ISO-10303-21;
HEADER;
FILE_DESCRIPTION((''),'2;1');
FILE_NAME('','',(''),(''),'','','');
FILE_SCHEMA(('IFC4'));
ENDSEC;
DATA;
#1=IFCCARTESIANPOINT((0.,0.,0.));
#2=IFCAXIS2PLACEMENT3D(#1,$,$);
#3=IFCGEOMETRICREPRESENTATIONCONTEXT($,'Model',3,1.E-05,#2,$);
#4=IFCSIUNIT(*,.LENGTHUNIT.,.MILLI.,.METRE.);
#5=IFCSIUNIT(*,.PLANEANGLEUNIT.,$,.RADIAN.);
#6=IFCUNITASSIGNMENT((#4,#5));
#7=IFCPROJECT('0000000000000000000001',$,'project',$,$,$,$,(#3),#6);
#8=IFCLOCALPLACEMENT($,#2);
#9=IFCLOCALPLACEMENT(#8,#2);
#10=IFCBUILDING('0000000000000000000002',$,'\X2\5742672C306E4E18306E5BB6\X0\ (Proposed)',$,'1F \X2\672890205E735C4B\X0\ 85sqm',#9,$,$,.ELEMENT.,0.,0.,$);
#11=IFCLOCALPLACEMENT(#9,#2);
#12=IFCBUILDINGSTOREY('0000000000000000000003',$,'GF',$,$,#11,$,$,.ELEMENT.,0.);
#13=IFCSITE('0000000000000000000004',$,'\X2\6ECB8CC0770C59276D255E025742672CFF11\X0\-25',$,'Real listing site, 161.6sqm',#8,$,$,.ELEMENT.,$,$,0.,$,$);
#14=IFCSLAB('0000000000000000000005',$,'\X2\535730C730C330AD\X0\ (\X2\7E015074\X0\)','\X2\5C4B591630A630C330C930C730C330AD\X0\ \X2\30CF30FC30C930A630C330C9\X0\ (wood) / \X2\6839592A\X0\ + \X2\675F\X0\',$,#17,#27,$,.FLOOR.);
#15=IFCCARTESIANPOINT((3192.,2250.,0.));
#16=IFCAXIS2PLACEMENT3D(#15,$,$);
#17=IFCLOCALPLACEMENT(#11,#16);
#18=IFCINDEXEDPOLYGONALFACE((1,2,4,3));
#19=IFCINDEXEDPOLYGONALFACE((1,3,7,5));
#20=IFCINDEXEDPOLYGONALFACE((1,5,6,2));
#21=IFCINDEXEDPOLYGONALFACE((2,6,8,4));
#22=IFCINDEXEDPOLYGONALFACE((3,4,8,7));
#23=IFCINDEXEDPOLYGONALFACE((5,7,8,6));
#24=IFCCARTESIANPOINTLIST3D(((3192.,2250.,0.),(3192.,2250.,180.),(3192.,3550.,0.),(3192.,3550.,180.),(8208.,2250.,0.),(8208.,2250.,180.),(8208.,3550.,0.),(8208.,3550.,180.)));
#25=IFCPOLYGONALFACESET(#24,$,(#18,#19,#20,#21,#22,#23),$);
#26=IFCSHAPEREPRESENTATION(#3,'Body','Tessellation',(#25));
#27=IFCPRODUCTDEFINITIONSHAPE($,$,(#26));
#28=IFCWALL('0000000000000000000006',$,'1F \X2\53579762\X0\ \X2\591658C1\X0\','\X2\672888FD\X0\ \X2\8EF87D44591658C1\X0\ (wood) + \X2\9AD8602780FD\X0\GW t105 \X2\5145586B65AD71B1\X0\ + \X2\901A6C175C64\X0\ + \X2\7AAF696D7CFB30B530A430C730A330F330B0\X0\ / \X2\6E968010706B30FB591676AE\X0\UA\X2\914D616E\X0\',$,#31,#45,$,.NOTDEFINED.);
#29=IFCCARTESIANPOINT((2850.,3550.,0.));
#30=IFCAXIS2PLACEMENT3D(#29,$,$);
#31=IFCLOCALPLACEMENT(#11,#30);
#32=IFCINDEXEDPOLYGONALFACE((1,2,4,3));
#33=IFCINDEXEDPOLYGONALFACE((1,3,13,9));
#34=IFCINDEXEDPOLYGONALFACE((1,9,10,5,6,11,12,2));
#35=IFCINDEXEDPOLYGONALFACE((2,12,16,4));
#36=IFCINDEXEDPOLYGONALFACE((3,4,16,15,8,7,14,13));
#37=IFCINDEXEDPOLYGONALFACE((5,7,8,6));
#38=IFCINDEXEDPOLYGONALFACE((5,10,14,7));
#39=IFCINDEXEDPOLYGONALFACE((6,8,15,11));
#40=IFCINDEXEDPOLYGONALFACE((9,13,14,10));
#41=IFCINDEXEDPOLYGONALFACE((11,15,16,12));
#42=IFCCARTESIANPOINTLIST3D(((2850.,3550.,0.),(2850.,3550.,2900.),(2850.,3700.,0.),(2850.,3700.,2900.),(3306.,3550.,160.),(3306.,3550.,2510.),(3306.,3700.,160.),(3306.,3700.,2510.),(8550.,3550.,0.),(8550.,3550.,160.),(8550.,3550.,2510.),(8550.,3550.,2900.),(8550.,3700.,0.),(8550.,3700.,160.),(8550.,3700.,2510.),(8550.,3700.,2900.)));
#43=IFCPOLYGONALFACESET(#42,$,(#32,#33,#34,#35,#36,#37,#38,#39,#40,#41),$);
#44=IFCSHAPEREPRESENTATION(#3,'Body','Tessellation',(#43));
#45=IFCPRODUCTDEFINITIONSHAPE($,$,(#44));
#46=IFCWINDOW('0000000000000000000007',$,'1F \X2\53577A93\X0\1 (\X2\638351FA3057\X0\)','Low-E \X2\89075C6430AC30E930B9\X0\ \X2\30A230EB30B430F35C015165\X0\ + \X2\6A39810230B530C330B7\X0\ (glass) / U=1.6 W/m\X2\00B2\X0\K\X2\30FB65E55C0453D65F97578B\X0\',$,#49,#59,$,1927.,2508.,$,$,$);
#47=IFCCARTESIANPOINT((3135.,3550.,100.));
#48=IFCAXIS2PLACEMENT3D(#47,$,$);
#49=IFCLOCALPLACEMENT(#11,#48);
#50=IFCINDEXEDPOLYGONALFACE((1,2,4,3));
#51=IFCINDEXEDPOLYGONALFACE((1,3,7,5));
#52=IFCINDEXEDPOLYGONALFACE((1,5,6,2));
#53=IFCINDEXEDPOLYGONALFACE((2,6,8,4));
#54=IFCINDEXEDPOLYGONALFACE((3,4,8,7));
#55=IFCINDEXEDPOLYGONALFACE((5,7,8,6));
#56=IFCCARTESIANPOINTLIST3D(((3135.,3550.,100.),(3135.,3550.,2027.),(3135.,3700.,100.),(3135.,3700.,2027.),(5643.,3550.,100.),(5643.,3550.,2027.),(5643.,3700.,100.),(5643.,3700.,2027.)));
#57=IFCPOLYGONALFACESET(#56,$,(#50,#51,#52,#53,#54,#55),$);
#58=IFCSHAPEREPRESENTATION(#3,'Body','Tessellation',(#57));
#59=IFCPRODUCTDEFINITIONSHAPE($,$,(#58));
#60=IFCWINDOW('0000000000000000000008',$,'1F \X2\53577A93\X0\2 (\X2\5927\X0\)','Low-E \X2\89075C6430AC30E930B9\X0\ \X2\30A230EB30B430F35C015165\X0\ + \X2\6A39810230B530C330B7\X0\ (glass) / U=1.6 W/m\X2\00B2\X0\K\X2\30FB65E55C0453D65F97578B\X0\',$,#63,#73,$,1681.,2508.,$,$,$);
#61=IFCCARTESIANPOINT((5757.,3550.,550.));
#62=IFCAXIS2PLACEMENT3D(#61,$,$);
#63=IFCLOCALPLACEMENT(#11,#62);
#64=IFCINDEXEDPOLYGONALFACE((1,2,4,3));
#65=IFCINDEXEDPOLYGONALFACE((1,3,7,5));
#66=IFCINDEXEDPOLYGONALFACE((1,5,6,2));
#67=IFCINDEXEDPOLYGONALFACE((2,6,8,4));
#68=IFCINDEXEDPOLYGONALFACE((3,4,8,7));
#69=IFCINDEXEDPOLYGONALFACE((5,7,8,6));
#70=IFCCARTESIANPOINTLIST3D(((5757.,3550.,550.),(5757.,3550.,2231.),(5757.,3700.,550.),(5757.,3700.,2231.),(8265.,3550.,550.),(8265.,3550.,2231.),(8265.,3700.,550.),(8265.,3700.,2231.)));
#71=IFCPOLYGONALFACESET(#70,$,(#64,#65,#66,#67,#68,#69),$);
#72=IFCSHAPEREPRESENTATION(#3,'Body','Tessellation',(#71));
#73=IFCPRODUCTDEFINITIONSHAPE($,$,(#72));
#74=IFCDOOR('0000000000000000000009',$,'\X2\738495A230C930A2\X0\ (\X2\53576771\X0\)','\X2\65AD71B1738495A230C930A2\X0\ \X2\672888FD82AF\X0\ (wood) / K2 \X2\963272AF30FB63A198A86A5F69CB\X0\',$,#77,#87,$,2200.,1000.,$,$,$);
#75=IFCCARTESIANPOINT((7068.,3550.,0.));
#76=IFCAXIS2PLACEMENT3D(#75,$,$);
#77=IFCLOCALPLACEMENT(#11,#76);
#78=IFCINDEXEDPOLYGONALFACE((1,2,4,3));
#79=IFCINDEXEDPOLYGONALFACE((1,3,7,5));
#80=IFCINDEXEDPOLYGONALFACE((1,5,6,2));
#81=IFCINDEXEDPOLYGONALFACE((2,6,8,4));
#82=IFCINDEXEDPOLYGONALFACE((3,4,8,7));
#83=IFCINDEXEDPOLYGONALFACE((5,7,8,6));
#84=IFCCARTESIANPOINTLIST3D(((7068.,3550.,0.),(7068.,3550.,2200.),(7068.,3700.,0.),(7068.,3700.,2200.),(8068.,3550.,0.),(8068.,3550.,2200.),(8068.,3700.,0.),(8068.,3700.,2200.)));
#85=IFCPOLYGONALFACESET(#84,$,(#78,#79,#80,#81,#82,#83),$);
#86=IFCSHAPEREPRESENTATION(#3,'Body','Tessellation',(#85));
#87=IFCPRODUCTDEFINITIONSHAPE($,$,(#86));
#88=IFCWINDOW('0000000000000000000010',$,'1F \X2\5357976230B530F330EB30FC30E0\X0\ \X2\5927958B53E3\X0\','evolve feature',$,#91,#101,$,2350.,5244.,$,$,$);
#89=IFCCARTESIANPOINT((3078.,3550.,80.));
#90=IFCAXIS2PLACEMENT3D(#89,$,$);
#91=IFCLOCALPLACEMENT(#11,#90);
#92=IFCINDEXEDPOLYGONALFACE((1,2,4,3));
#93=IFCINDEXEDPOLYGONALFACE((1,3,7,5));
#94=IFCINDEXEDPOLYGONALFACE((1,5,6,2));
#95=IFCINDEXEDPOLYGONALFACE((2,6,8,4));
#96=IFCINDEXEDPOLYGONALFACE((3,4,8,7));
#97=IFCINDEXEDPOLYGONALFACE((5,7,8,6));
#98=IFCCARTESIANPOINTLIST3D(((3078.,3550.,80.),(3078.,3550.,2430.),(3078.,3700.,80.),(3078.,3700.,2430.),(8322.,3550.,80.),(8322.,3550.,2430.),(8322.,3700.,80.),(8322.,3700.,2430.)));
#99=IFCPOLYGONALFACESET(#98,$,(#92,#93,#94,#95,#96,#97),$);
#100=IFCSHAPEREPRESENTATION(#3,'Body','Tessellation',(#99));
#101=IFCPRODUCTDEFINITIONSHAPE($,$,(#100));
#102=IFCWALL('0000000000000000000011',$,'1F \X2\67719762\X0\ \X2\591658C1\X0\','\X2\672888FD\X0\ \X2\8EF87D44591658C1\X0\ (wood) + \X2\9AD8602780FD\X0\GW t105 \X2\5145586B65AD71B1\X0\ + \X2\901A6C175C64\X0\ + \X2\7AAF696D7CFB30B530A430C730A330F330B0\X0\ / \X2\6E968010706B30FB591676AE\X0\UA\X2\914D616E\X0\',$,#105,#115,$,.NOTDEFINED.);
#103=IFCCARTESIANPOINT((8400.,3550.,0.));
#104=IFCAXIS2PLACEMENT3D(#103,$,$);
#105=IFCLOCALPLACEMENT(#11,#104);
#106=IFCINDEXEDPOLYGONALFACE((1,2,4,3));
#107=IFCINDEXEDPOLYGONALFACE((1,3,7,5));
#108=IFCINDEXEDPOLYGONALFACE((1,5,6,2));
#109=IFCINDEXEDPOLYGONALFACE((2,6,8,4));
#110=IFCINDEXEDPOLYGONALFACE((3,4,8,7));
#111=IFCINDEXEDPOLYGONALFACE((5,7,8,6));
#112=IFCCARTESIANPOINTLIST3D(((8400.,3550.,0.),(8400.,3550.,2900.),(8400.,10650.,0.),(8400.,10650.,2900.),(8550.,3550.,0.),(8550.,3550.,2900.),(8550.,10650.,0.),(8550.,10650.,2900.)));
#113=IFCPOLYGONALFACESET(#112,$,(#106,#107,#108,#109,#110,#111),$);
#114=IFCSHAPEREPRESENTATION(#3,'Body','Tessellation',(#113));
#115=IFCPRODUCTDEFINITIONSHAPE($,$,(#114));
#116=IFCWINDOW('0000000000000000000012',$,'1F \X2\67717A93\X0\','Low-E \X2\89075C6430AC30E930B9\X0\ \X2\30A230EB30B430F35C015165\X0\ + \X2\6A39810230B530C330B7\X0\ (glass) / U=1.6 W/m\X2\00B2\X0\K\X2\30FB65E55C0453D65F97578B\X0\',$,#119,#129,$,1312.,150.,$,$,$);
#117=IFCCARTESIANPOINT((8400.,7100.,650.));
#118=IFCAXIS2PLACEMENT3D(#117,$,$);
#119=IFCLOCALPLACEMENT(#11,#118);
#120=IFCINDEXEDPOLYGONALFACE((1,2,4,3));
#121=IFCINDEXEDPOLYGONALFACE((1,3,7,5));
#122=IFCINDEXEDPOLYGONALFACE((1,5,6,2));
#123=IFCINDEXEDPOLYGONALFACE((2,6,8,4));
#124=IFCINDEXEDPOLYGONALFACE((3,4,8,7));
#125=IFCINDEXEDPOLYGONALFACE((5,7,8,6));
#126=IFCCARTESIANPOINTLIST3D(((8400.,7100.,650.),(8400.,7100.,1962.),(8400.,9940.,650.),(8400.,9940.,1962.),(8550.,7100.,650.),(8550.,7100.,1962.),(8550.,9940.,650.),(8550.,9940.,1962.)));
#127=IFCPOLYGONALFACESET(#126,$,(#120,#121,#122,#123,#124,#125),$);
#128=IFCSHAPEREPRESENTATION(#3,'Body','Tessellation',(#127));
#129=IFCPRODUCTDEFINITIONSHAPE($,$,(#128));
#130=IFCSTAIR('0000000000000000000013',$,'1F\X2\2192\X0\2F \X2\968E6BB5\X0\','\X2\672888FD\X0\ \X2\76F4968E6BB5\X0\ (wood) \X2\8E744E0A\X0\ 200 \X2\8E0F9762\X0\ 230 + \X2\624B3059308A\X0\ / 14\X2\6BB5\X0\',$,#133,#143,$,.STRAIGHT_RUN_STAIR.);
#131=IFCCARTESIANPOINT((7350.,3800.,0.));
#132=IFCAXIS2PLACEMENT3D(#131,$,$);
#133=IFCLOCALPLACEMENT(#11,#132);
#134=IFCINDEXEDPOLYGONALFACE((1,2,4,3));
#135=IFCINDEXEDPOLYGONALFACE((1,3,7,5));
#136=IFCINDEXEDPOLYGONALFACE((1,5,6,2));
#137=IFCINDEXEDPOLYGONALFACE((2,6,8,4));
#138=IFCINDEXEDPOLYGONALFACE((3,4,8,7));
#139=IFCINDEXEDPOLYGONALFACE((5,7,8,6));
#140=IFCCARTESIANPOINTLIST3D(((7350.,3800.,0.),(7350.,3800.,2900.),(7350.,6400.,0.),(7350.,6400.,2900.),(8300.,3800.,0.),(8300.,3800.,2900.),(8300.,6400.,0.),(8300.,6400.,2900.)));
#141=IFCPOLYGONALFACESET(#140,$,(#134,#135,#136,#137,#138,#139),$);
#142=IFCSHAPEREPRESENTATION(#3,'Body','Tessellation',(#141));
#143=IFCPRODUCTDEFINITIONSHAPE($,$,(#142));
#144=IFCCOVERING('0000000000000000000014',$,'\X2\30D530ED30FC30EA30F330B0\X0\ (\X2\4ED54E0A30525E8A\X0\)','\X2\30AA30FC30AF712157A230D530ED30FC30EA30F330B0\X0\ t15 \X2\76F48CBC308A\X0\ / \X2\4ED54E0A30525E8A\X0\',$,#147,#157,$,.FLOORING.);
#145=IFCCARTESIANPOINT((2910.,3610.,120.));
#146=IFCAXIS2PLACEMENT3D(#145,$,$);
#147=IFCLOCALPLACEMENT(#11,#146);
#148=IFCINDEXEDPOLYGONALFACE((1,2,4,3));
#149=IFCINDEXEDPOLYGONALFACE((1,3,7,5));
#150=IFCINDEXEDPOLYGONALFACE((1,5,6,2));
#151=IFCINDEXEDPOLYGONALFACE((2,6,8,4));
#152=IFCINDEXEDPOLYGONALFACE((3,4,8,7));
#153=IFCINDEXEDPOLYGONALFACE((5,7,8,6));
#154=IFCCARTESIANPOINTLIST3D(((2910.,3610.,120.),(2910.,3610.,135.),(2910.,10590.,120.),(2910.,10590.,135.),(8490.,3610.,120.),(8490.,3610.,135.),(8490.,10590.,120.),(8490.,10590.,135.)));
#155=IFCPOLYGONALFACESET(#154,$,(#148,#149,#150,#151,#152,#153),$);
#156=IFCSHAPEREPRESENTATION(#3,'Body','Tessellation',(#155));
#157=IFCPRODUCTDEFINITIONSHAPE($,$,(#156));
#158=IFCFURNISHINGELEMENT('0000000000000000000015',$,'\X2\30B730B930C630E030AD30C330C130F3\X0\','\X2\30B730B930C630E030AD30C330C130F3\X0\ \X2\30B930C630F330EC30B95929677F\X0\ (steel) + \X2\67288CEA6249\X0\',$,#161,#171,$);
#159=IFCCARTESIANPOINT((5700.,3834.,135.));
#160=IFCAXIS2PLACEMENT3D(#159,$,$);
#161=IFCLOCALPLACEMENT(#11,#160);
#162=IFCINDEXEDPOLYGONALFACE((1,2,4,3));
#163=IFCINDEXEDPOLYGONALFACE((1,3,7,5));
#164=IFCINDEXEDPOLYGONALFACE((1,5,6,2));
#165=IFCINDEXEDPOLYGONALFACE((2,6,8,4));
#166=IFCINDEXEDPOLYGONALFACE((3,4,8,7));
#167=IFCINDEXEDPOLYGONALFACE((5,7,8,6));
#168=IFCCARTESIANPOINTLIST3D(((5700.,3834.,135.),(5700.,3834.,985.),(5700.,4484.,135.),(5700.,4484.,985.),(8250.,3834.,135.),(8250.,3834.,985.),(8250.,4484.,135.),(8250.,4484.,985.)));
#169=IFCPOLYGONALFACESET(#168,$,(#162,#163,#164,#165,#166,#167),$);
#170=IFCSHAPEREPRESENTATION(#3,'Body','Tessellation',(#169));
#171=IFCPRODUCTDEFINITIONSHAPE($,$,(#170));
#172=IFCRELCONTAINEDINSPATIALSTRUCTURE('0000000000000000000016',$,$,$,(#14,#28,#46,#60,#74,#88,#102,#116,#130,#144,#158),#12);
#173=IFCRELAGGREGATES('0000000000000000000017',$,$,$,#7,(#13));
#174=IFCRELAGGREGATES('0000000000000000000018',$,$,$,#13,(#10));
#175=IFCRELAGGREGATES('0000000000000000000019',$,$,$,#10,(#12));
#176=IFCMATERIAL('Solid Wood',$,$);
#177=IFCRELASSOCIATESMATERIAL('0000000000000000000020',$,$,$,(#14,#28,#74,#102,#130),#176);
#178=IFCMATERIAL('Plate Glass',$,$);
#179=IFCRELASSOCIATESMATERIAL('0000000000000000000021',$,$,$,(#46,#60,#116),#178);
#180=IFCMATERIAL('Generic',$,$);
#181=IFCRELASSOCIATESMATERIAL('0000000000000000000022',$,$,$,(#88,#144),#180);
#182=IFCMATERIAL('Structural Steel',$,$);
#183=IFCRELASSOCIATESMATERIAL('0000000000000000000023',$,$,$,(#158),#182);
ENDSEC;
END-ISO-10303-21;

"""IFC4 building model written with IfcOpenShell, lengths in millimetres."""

from ifc_helpers import new_model, si_unit, frame, frame_2d, origin, place, context, project, spatial, rectangle, extrude, material, element, fill, save


model = new_model("IFC4")

# Units and contexts
model_context = context("Model", 3, precision=1e-05, world=origin())
ifc_project = project(units=[si_unit("LENGTHUNIT", "METRE", prefix="MILLI"), si_unit("PLANEANGLEUNIT", "RADIAN")], contexts=[model_context])

# Site, building, storey
site_placement = place(None, origin())
site = spatial("IfcSite", under=ifc_project, at=site_placement, Name="滋賀県大津市坂本１-25", ObjectType="Real listing site, 161.6sqm", CompositionType="ELEMENT", RefElevation=0.0)
building_placement = place(site_placement, origin())
building = spatial("IfcBuilding", under=site, at=building_placement, Name="坂本の丘の家 (Proposed)", ObjectType="1F 木造平屋 85sqm", CompositionType="ELEMENT", ElevationOfRefHeight=0.0, ElevationOfTerrain=0.0)
storey_placement = place(building_placement, origin())
storey = spatial("IfcBuildingStorey", under=building, at=storey_placement, Name="GF", CompositionType="ELEMENT", Elevation=0.0)

# Slab
ifc_material_1 = material(Name="Solid Wood")
slab_1_placement = place(storey_placement, frame((3192.0, 2250.0, 0.0)))
element("IfcSlab", 1, at=slab_1_placement, inside=storey, material=ifc_material_1, Name="南デッキ (縁側)", Description="屋外ウッドデッキ ハードウッド (wood) / 根太 + 束", PredefinedType="FLOOR", context=model_context, shape_type="SweptSolid", body=[
    extrude(rectangle(XDim=5016.0, YDim=1300.0, at=frame_2d((2508.0, 650.0))), frame((3192.0, 2250.0, 0.0)), (0.0, 0.0, 1.0), 180.0),
])
ifc_material_2 = material(Name="Generic")

# Wall, openings, windows, door
wall_1_placement = place(storey_placement, frame((2850.0, 3550.0, 0.0)))
wall_1 = element("IfcWall", 2, at=wall_1_placement, inside=storey, material=ifc_material_1, Name="1F 南面 外壁", Description="木製 軸組外壁 (wood) + 高性能GW t105 充填断熱 + 通気層 + 窯業系サイディング / 準耐火・外皮UA配慮", PredefinedType="NOTDEFINED", context=model_context, shape_type="SweptSolid", body=[
    extrude(rectangle(XDim=5700.0, YDim=150.0, at=frame_2d((2850.0, 75.0))), frame((2850.0, 3550.0, 0.0)), (0.0, 0.0, 1.0), 2900.0),
])
opening_1_placement = place(storey_placement, frame((3135.0, 3550.0, 100.0)))
opening_1 = element("IfcOpeningElement", 3, at=opening_1_placement, cuts=wall_1, PredefinedType="NOTDEFINED", context=model_context, shape_type="SweptSolid", body=[
    extrude(rectangle(XDim=2508.0, YDim=150.0, at=frame_2d((1254.0, 75.0))), frame((3135.0, 3550.0, 100.0)), (0.0, 0.0, 1.0), 1927.0),
])
opening_2_placement = place(storey_placement, frame((5757.0, 3550.0, 550.0)))
opening_2 = element("IfcOpeningElement", 4, at=opening_2_placement, cuts=wall_1, PredefinedType="NOTDEFINED", context=model_context, shape_type="SweptSolid", body=[
    extrude(rectangle(XDim=2508.0, YDim=150.0, at=frame_2d((1254.0, 75.0))), frame((5757.0, 3550.0, 550.0)), (0.0, 0.0, 1.0), 1681.0),
])
opening_3_placement = place(storey_placement, frame((7068.0, 3550.0, 0.0)))
opening_3 = element("IfcOpeningElement", 5, at=opening_3_placement, cuts=wall_1, PredefinedType="NOTDEFINED", context=model_context, shape_type="SweptSolid", body=[
    extrude(rectangle(XDim=1000.0, YDim=150.0, at=frame_2d((500.0, 75.0))), frame((7068.0, 3550.0, 0.0)), (0.0, 0.0, 1.0), 2200.0),
])
opening_4_placement = place(storey_placement, frame((3078.0, 3550.0, 80.0)))
opening_4 = element("IfcOpeningElement", 6, at=opening_4_placement, cuts=wall_1, PredefinedType="NOTDEFINED", context=model_context, shape_type="SweptSolid", body=[
    extrude(rectangle(XDim=5244.0, YDim=150.0, at=frame_2d((2622.0, 75.0))), frame((3078.0, 3550.0, 80.0)), (0.0, 0.0, 1.0), 2350.0),
])
ifc_material_3 = material(Name="Plate Glass")
window_1_placement = place(storey_placement, frame((3135.0, 3550.0, 100.0)))
window_1 = element("IfcWindow", 7, at=window_1_placement, inside=storey, material=ifc_material_3, Name="1F 南窓1 (掃出し)", Description="Low-E 複層ガラス アルゴン封入 + 樹脂サッシ (glass) / U=1.6 W/m²K・日射取得型", OverallHeight=1927.0, OverallWidth=2508.0, context=model_context, shape_type="SweptSolid", body=[
    extrude(rectangle(XDim=2508.0, YDim=150.0, at=frame_2d((1254.0, 75.0))), frame((3135.0, 3550.0, 100.0)), (0.0, 0.0, 1.0), 1927.0),
])
fill(opening_1, window_1)
window_2_placement = place(storey_placement, frame((5757.0, 3550.0, 550.0)))
window_2 = element("IfcWindow", 8, at=window_2_placement, inside=storey, material=ifc_material_3, Name="1F 南窓2 (大)", Description="Low-E 複層ガラス アルゴン封入 + 樹脂サッシ (glass) / U=1.6 W/m²K・日射取得型", OverallHeight=1681.0, OverallWidth=2508.0, context=model_context, shape_type="SweptSolid", body=[
    extrude(rectangle(XDim=2508.0, YDim=150.0, at=frame_2d((1254.0, 75.0))), frame((5757.0, 3550.0, 550.0)), (0.0, 0.0, 1.0), 1681.0),
])
fill(opening_2, window_2)
door_placement = place(storey_placement, frame((7068.0, 3550.0, 0.0)))
door = element("IfcDoor", 9, at=door_placement, inside=storey, material=ifc_material_1, Name="玄関ドア (南東)", Description="断熱玄関ドア 木製芯 (wood) / K2 防犯・採風機構", OverallHeight=2200.0, OverallWidth=1000.0, context=model_context, shape_type="SweptSolid", body=[
    extrude(rectangle(XDim=1000.0, YDim=150.0, at=frame_2d((500.0, 75.0))), frame((7068.0, 3550.0, 0.0)), (0.0, 0.0, 1.0), 2200.0),
])
fill(opening_3, door)
window_3_placement = place(storey_placement, frame((3078.0, 3550.0, 80.0)))
window_3 = element("IfcWindow", 10, at=window_3_placement, inside=storey, material=ifc_material_2, Name="1F 南面サンルーム 大開口", Description="evolve feature", OverallHeight=2350.0, OverallWidth=5244.0, context=model_context, shape_type="SweptSolid", body=[
    extrude(rectangle(XDim=5244.0, YDim=150.0, at=frame_2d((2622.0, 75.0))), frame((3078.0, 3550.0, 80.0)), (0.0, 0.0, 1.0), 2350.0),
])
fill(opening_4, window_3)

# Wall, opening, window
wall_2_placement = place(storey_placement, frame((8400.0, 3550.0, 0.0)))
wall_2 = element("IfcWall", 11, at=wall_2_placement, inside=storey, material=ifc_material_1, Name="1F 東面 外壁", Description="木製 軸組外壁 (wood) + 高性能GW t105 充填断熱 + 通気層 + 窯業系サイディング / 準耐火・外皮UA配慮", PredefinedType="NOTDEFINED", context=model_context, shape_type="SweptSolid", body=[
    extrude(rectangle(XDim=150.0, YDim=7100.0, at=frame_2d((75.0, 3550.0))), frame((8400.0, 3550.0, 0.0)), (0.0, 0.0, 1.0), 2900.0),
])
opening_5_placement = place(storey_placement, frame((8400.0, 7100.0, 650.0)))
opening_5 = element("IfcOpeningElement", 12, at=opening_5_placement, cuts=wall_2, PredefinedType="NOTDEFINED", context=model_context, shape_type="SweptSolid", body=[
    extrude(rectangle(XDim=150.0, YDim=2840.0, at=frame_2d((75.0, 1420.0))), frame((8400.0, 7100.0, 650.0)), (0.0, 0.0, 1.0), 1312.0),
])
window_4_placement = place(storey_placement, frame((8400.0, 7100.0, 650.0)))
window_4 = element("IfcWindow", 13, at=window_4_placement, inside=storey, material=ifc_material_3, Name="1F 東窓", Description="Low-E 複層ガラス アルゴン封入 + 樹脂サッシ (glass) / U=1.6 W/m²K・日射取得型", OverallHeight=1312.0, OverallWidth=150.0, context=model_context, shape_type="SweptSolid", body=[
    extrude(rectangle(XDim=150.0, YDim=2840.0, at=frame_2d((75.0, 1420.0))), frame((8400.0, 7100.0, 650.0)), (0.0, 0.0, 1.0), 1312.0),
])
fill(opening_5, window_4)

# Stair
stair_placement = place(storey_placement, frame((7350.0, 3800.0, 0.0)))
element("IfcStair", 14, at=stair_placement, inside=storey, material=ifc_material_1, Name="1F→2F 階段", Description="木製 直階段 (wood) 蹴上 200 踏面 230 + 手すり / 14段", PredefinedType="STRAIGHT_RUN_STAIR", context=model_context, shape_type="SweptSolid", body=[
    extrude(rectangle(XDim=950.0, YDim=2600.0, at=frame_2d((475.0, 1300.0))), frame((7350.0, 3800.0, 0.0)), (0.0, 0.0, 1.0), 2900.0),
])

# Covering
covering_placement = place(storey_placement, frame((2910.0, 3610.0, 120.0)))
element("IfcCovering", 15, at=covering_placement, inside=storey, material=ifc_material_2, Name="フローリング (仕上げ床)", Description="オーク無垢フローリング t15 直貼り / 仕上げ床", PredefinedType="FLOORING", context=model_context, shape_type="SweptSolid", body=[
    extrude(rectangle(XDim=5580.0, YDim=6980.0, at=frame_2d((2790.0, 3490.0))), frame((2910.0, 3610.0, 120.0)), (0.0, 0.0, 1.0), 15.0),
])

# Furnishing element
ifc_material_4 = material(Name="Structural Steel")
furnishing_placement = place(storey_placement, frame((5700.0, 3834.0, 135.0)))
element("IfcFurnishingElement", 16, at=furnishing_placement, inside=storey, material=ifc_material_4, Name="システムキッチン", Description="システムキッチン ステンレス天板 (steel) + 木質扉", context=model_context, shape_type="SweptSolid", body=[
    extrude(rectangle(XDim=2550.0, YDim=650.0, at=frame_2d((1275.0, 325.0))), frame((5700.0, 3834.0, 135.0)), (0.0, 0.0, 1.0), 850.0),
])

save(model, "model.ifc")
